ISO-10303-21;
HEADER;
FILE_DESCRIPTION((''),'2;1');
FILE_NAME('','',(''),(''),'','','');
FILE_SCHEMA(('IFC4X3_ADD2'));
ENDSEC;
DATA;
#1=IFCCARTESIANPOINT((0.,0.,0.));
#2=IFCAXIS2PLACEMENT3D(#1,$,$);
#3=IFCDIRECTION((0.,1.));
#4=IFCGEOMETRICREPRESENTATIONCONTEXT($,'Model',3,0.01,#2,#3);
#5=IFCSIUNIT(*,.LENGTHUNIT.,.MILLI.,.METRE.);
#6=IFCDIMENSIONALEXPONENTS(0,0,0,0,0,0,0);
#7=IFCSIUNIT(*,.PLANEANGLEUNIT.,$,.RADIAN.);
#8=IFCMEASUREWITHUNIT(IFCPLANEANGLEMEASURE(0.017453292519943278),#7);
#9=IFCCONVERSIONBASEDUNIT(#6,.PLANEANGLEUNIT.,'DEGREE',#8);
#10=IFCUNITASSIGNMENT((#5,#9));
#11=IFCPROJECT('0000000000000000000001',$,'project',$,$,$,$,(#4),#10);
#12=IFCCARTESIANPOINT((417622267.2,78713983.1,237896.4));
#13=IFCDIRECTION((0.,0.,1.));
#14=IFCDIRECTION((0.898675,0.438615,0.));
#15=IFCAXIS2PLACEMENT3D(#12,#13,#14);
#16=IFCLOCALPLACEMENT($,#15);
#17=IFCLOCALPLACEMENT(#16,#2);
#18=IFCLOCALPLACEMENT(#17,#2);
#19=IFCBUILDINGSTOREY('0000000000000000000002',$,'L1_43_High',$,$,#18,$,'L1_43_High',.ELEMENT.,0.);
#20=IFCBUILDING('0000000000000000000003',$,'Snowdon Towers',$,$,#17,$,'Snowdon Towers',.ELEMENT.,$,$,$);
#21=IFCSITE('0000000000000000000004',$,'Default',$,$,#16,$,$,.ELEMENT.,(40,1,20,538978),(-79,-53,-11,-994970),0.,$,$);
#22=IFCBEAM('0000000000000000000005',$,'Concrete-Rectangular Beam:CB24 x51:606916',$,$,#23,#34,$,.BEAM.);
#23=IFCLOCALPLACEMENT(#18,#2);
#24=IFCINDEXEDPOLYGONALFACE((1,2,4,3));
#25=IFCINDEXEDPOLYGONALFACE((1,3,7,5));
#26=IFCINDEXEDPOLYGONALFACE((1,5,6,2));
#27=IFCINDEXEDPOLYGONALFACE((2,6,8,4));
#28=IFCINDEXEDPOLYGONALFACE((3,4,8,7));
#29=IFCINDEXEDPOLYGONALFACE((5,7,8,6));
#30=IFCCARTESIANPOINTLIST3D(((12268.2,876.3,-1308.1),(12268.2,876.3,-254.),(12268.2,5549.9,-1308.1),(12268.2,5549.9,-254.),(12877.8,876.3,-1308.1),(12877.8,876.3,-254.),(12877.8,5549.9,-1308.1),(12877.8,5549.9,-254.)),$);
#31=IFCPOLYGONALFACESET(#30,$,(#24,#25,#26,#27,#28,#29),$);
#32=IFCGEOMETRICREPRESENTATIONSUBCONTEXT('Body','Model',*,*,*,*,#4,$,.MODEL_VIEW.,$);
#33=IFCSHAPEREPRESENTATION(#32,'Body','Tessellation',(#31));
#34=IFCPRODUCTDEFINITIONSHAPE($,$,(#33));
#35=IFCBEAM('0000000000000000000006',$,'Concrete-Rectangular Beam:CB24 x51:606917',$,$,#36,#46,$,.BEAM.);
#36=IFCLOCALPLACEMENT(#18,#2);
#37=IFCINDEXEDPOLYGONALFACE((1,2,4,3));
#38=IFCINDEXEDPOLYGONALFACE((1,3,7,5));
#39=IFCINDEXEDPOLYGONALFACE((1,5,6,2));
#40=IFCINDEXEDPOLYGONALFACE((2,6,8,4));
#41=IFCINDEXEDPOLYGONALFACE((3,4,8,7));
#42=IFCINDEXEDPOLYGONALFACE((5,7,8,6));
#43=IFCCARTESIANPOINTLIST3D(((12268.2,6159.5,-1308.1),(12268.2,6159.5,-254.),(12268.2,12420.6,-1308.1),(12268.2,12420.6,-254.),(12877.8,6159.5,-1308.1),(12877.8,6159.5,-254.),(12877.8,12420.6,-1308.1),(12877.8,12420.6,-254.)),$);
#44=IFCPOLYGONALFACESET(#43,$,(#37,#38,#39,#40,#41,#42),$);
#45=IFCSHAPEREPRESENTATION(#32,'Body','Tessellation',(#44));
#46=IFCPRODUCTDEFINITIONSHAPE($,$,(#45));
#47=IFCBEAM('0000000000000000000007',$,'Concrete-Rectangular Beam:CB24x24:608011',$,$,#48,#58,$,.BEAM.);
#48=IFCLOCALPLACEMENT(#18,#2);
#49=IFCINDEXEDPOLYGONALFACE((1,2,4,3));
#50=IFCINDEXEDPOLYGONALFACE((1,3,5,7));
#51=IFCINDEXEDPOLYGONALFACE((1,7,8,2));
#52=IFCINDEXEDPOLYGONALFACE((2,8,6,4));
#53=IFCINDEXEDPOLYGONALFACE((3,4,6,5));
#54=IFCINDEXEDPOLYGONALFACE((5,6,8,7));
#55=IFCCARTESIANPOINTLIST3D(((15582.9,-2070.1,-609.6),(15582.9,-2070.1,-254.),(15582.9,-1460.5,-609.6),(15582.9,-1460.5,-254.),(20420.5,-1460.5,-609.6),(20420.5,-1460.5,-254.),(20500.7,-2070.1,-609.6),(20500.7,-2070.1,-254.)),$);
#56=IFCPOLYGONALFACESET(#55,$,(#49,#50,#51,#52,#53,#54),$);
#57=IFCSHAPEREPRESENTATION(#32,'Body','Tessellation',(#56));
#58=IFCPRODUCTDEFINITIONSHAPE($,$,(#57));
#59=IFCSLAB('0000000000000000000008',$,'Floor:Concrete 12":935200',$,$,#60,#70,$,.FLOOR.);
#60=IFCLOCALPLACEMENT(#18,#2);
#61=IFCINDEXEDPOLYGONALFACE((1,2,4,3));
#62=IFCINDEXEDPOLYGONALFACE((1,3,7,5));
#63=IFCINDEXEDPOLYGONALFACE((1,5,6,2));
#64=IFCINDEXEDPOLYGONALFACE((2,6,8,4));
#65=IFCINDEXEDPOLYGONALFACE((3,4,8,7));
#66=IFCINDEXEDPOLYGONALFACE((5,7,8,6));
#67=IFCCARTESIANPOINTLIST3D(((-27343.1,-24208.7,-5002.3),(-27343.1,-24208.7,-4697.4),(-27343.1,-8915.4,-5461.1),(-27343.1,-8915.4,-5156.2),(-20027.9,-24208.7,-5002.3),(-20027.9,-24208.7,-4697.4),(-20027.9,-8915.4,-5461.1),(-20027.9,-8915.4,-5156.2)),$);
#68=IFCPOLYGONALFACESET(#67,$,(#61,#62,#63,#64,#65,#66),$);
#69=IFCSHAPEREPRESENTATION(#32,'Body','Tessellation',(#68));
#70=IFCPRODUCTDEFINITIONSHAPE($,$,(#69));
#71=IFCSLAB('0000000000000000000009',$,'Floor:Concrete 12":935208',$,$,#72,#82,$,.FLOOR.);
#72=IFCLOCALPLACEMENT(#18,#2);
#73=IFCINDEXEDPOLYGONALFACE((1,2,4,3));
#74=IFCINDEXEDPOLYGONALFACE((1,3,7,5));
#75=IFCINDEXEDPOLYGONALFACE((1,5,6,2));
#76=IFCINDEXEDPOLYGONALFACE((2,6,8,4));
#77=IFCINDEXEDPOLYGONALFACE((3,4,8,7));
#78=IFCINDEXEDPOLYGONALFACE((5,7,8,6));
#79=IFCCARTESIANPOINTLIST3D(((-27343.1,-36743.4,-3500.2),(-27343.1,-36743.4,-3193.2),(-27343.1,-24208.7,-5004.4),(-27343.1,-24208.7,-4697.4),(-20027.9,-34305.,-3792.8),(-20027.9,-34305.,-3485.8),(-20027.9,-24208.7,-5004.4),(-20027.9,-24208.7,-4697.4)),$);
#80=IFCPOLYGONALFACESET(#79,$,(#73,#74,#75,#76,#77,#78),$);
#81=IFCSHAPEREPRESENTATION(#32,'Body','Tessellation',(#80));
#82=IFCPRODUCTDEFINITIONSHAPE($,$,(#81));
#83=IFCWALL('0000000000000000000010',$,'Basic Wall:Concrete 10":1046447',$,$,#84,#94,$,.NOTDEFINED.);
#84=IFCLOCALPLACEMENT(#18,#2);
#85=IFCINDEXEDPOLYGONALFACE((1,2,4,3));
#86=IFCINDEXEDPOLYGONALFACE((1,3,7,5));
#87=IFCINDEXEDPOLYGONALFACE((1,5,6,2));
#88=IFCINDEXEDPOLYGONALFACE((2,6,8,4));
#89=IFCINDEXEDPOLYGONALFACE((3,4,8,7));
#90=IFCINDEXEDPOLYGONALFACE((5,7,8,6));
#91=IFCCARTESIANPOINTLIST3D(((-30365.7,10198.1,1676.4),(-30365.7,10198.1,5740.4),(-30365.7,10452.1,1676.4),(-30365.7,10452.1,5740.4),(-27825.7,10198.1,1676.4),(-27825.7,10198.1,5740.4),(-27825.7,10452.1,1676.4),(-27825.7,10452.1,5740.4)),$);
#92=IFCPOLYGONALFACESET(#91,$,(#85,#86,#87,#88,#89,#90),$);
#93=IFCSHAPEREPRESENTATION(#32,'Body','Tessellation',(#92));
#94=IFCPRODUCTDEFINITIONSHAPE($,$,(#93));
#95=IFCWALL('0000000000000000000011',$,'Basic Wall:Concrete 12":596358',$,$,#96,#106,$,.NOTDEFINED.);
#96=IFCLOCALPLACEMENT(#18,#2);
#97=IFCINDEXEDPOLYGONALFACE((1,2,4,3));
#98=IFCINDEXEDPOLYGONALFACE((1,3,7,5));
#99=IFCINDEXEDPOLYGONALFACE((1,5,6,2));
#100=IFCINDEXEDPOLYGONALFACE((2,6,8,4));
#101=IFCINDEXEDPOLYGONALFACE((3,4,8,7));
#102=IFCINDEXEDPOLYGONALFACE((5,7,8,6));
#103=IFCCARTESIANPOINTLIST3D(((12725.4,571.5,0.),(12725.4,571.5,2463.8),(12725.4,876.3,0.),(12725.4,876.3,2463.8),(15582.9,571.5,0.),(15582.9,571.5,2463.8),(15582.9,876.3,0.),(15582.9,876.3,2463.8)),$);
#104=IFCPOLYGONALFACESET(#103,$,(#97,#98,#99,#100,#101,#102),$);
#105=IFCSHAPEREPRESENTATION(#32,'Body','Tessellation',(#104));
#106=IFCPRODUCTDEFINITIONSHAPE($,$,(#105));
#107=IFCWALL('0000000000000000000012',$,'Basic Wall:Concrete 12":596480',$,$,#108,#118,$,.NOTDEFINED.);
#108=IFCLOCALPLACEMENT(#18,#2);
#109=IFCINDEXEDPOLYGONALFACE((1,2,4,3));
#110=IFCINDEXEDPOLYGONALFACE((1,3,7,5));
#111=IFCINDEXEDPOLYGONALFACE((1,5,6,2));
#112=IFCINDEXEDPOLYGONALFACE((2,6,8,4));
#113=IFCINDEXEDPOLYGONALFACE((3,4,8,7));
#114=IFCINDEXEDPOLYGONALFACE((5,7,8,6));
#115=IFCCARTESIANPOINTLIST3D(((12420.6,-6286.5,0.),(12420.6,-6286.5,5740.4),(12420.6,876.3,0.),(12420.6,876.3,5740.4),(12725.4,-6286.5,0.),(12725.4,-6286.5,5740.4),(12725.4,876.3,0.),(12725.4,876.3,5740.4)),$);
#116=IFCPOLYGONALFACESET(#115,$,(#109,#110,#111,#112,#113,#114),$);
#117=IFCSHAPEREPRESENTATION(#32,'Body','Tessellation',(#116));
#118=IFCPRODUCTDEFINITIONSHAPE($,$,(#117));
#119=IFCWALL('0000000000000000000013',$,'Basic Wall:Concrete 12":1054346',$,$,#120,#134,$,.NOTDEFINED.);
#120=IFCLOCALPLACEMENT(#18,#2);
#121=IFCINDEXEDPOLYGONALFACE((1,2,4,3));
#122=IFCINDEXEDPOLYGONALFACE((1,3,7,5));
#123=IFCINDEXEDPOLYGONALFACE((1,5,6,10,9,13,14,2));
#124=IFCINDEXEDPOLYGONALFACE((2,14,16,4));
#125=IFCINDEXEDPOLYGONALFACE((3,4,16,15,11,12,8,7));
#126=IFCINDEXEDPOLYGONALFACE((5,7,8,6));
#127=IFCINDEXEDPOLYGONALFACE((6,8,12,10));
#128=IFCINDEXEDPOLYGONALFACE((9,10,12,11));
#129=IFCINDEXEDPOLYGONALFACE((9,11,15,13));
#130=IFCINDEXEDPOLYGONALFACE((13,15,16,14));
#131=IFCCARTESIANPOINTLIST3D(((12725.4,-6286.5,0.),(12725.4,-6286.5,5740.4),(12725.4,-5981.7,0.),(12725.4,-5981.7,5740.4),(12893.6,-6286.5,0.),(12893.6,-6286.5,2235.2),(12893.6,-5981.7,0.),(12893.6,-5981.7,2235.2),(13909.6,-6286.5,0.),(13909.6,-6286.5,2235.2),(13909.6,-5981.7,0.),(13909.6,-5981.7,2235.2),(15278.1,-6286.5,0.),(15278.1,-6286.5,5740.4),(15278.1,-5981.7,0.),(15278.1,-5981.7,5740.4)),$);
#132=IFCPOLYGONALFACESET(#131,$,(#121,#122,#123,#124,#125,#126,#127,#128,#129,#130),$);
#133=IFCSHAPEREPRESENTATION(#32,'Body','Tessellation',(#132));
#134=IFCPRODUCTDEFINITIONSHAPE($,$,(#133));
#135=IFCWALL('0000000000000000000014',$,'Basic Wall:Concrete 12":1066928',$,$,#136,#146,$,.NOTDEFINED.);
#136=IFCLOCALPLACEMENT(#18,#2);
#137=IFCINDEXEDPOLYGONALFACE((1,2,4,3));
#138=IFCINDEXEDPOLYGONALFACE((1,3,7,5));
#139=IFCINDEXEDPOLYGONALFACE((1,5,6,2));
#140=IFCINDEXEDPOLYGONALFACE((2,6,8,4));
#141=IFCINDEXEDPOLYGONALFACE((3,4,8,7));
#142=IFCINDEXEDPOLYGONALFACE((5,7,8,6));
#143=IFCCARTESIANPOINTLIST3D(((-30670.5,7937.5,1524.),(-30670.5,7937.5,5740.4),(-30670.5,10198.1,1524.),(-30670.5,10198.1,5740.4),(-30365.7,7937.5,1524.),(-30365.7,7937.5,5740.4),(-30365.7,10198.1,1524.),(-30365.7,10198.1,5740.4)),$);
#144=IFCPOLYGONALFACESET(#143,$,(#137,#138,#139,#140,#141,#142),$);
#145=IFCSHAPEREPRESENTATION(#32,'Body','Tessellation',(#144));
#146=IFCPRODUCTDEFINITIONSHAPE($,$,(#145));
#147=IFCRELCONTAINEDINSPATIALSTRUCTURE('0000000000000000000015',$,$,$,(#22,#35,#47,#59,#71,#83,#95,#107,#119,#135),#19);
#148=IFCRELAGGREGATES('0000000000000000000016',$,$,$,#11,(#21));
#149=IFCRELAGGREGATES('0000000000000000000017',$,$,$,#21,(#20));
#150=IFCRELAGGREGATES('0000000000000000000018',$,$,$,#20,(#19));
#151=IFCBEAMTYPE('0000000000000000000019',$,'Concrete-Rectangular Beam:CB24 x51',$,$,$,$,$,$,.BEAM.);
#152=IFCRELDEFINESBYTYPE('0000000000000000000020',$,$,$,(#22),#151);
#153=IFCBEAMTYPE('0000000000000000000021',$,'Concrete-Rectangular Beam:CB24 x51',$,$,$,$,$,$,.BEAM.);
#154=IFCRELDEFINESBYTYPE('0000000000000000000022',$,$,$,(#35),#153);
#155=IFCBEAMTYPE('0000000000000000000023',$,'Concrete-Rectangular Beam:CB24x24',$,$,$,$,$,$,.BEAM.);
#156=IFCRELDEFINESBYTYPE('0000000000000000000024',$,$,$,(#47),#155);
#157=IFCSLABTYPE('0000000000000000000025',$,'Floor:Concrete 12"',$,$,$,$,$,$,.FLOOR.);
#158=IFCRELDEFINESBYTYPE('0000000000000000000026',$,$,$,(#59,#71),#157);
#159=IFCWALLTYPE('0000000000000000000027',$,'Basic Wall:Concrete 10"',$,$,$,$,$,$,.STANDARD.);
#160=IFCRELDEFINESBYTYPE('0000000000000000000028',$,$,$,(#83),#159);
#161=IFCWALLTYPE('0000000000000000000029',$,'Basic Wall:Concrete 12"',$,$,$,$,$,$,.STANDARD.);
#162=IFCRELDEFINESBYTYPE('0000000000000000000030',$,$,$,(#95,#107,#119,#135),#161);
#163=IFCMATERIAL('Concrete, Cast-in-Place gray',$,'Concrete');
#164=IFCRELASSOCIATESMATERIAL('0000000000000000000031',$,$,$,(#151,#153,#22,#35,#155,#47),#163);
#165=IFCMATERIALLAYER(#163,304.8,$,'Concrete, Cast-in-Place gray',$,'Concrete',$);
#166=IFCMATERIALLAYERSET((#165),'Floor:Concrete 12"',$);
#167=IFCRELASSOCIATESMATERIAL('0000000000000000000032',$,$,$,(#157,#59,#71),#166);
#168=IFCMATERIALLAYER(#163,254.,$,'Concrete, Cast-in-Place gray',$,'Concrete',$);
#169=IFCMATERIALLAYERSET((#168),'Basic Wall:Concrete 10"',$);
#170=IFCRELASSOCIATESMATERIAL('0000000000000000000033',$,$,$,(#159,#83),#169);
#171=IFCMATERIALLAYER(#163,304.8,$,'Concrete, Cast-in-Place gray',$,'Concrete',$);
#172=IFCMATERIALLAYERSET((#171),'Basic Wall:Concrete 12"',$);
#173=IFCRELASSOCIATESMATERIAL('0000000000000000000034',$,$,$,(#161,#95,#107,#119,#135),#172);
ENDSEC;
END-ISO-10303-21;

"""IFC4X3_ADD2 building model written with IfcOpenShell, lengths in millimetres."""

from ifc_helpers import new_model, entity, si_unit, converted_unit, direction, frame, frame_2d, origin, place, context, subcontext, project, spatial, polyline, rectangle, outline, extrude, clip, halfspace, source, transform, mapped, material, layer, layer_set, layer_usage, material_profile, profile_set, profile_usage, type_object, type_shapes, element, save


model = new_model("IFC4X3_ADD2")

# Units and contexts
model_context = context("Model", 3, precision=0.01, world=origin(), true_north=direction((0.0, 1.0)))
body_context = subcontext(model_context, "Body", "Model", "MODEL_VIEW")
ifc_project = project(units=[si_unit("LENGTHUNIT", "METRE", prefix="MILLI"), converted_unit("PLANEANGLEUNIT", "DEGREE", entity("IfcPlaneAngleMeasure", 0.017453292519943278), si_unit("PLANEANGLEUNIT", "RADIAN"), dimensions=[0, 0, 0, 0, 0, 0, 0])], contexts=[model_context])

# Site, building, storey
site_placement = place(None, frame((417622267.2, 78713983.1, 237896.4), z_axis=(0.0, 0.0, 1.0), x_axis=(0.898675, 0.438615, 0.0)))
site = spatial("IfcSite", under=ifc_project, at=site_placement, Name="Default", CompositionType="ELEMENT", RefLatitude=(40, 1, 20, 538978), RefLongitude=(-79, -53, -11, -994970), RefElevation=0.0)
building_placement = place(site_placement, origin())
building = spatial("IfcBuilding", under=site, at=building_placement, Name="Snowdon Towers", LongName="Snowdon Towers", CompositionType="ELEMENT")
storey_placement = place(building_placement, origin())
storey = spatial("IfcBuildingStorey", under=building, at=storey_placement, Name="L1_43_High", LongName="L1_43_High", CompositionType="ELEMENT", Elevation=0.0)

# Beams
ifc_material_1 = material(Name="Concrete, Cast-in-Place gray", Category="Concrete")
ifc_material_profile_1 = material_profile(ifc_material_1, rectangle(XDim=355.6, YDim=609.6, at=frame_2d((0.0, 0.0), x_axis=(1.0, 0.0))), Name="CB24x24")
ifc_profile_set_1 = profile_set([ifc_material_profile_1], Name="CB24x24")
ifc_profile_usage_1 = profile_usage(ifc_profile_set_1, cardinal=8)
ifc_material_profile_2 = material_profile(ifc_material_1, rectangle(XDim=1054.1, YDim=609.6, at=frame_2d((0.0, 0.0), x_axis=(0.0, 1.0))), Name="CB24 x51")
ifc_profile_set_2 = profile_set([ifc_material_profile_2], Name="CB24 x51")
ifc_profile_usage_2 = profile_usage(ifc_profile_set_2, cardinal=8)
beam_type_1 = type_object("IfcBeamType", Name="Concrete-Rectangular Beam:CB24 x51", PredefinedType="BEAM", material=ifc_profile_set_2)
shared_shape_1 = source(origin(), body_context, "Body", "SweptSolid", [
    extrude(rectangle(XDim=1054.1, YDim=609.6, at=frame_2d((0.0, 0.0), x_axis=(0.0, 1.0))), frame((12573.0, 876.3, -781.0), z_axis=(0.0, 1.0, 0.0), x_axis=(-1.0, 0.0, 0.0)), (0.0, 0.0, 1.0), 4673.6),
])
type_shapes(beam_type_1, [shared_shape_1])
beam_1_placement = place(storey_placement, origin())
element("IfcBeam", 1, at=beam_1_placement, inside=storey, type_object=beam_type_1, material=ifc_profile_usage_2, Name="Concrete-Rectangular Beam:CB24 x51:606916", PredefinedType="BEAM", context=body_context, shape_type="MappedRepresentation", body=[
    mapped(shared_shape_1, transform((0.0, 0.0, 0.0), scale=1.0)),
])
beam_type_2 = type_object("IfcBeamType", Name="Concrete-Rectangular Beam:CB24 x51", PredefinedType="BEAM", material=ifc_profile_set_2)
shared_shape_2 = source(origin(), body_context, "Body", "SweptSolid", [
    extrude(rectangle(XDim=1054.1, YDim=609.6, at=frame_2d((0.0, 0.0), x_axis=(0.0, 1.0))), frame((12573.0, 6159.5, -781.0), z_axis=(0.0, 1.0, 0.0), x_axis=(-1.0, 0.0, 0.0)), (0.0, 0.0, 1.0), 6261.1),
])
type_shapes(beam_type_2, [shared_shape_2])
beam_2_placement = place(storey_placement, origin())
element("IfcBeam", 2, at=beam_2_placement, inside=storey, type_object=beam_type_2, material=ifc_profile_usage_2, Name="Concrete-Rectangular Beam:CB24 x51:606917", PredefinedType="BEAM", context=body_context, shape_type="MappedRepresentation", body=[
    mapped(shared_shape_2, transform((0.0, 0.0, 0.0), scale=1.0)),
])
beam_type_3 = type_object("IfcBeamType", Name="Concrete-Rectangular Beam:CB24x24", PredefinedType="BEAM", material=ifc_profile_set_1)
shared_shape_3 = source(origin(), body_context, "Body", "Clipping", [
    clip(extrude(rectangle(XDim=355.6, YDim=609.6, at=frame_2d((0.0, 0.0), x_axis=(1.0, 0.0))), frame((15582.9, -1765.3, -431.8), z_axis=(1.0, 0.0, 0.0), x_axis=(0.0, 0.0, -1.0)), (0.0, 0.0, 1.0), 4917.8), halfspace(frame((18529.5, 12902.8, -5334.0), z_axis=(0.991445, 0.130526, 0.0), x_axis=(0.130526, -0.991445, 0.0)), False)),
])
type_shapes(beam_type_3, [shared_shape_3])
beam_3_placement = place(storey_placement, origin())
element("IfcBeam", 3, at=beam_3_placement, inside=storey, type_object=beam_type_3, material=ifc_profile_usage_1, Name="Concrete-Rectangular Beam:CB24x24:608011", PredefinedType="BEAM", context=body_context, shape_type="MappedRepresentation", body=[
    mapped(shared_shape_3, transform((0.0, 0.0, 0.0), scale=1.0)),
])

# Slabs
ifc_layer_1 = layer(ifc_material_1, 304.8, Name="Concrete, Cast-in-Place gray", Category="Concrete")
ifc_layer_set_1 = layer_set([ifc_layer_1], Name="Floor:Concrete 12\"")
ifc_layer_usage_1 = layer_usage(ifc_layer_set_1, "AXIS3", "POSITIVE", 0.0)
slab_type_1 = type_object("IfcSlabType", Name="Floor:Concrete 12\"", PredefinedType="FLOOR", material=ifc_layer_set_1)
slab_1_placement = place(storey_placement, origin())
element("IfcSlab", 4, at=slab_1_placement, inside=storey, type_object=slab_type_1, material=ifc_layer_usage_1, Name="Floor:Concrete 12\":935200", PredefinedType="FLOOR", context=body_context, shape_type="Clipping", body=[
    clip(clip(extrude(rectangle(XDim=15300.2, YDim=7315.2, at=frame_2d((0.0, 0.0), x_axis=(1.0, 0.0))), frame((-23685.5, -16562.1, -4926.8), z_axis=(0.0, -0.029987, -0.99955), x_axis=(0.0, 0.99955, -0.029987)), (0.029987, 0.0, 0.99955), 305.1), halfspace(frame((-23685.5, -8915.4, -5461.1), z_axis=(0.0, -0.029987, -0.99955), x_axis=(0.0, -0.99955, 0.029987)), False)), halfspace(frame((-23685.5, -8915.4, -5156.2), z_axis=(0.0, 0.029987, 0.99955), x_axis=(0.0, 0.99955, -0.029987)), False)),
])
ifc_layer_usage_2 = layer_usage(ifc_layer_set_1, "AXIS3", "POSITIVE", 0.0)
slab_2_placement = place(storey_placement, origin())
element("IfcSlab", 5, at=slab_2_placement, inside=storey, type_object=slab_type_1, material=ifc_layer_usage_2, Name="Floor:Concrete 12\":935208", PredefinedType="FLOOR", context=body_context, shape_type="Clipping", body=[
    clip(clip(extrude(outline(polyline([(-6926.3, -3657.6), (5698.3, -3657.6), (5698.3, 3657.6), (-4470.4, 3657.6), (-6926.3, -3657.6)])), frame((-23685.5, -29866.5, -4018.5), z_axis=(0.0, -0.119145, -0.992877), x_axis=(0.0, 0.992877, -0.119145)), (0.119145, 0.0, 0.992877), 309.2), halfspace(frame((-23685.5, -24208.7, -5004.4), z_axis=(0.0, -0.119145, -0.992877), x_axis=(0.0, -0.992877, 0.119145)), False)), halfspace(frame((-23685.5, -24208.7, -4697.4), z_axis=(0.0, 0.119145, 0.992877), x_axis=(0.0, 0.992877, -0.119145)), False)),
])

# Walls
ifc_layer_2 = layer(ifc_material_1, 254.0, Name="Concrete, Cast-in-Place gray", Category="Concrete")
ifc_layer_set_2 = layer_set([ifc_layer_2], Name="Basic Wall:Concrete 10\"")
wall_type_1 = type_object("IfcWallType", Name="Basic Wall:Concrete 10\"", PredefinedType="STANDARD", material=ifc_layer_set_2)
wall_1_placement = place(storey_placement, frame((-30365.7, 10325.1, 1676.4)))
element("IfcWall", 6, at=wall_1_placement, inside=storey, type_object=wall_type_1, material=ifc_layer_set_2, Name="Basic Wall:Concrete 10\":1046447", PredefinedType="NOTDEFINED", context=body_context, shape_type="SweptSolid", body=[
    extrude(rectangle(XDim=2540.0, YDim=254.0, at=frame_2d((1270.0, 0.0), x_axis=(-1.0, 0.0))), origin(), (0.0, 0.0, 1.0), 4064.0),
])
ifc_layer_3 = layer(ifc_material_1, 304.8, Name="Concrete, Cast-in-Place gray", Category="Concrete")
ifc_layer_set_3 = layer_set([ifc_layer_3], Name="Basic Wall:Concrete 12\"")
wall_type_2 = type_object("IfcWallType", Name="Basic Wall:Concrete 12\"", PredefinedType="STANDARD", material=ifc_layer_set_3)
wall_2_placement = place(storey_placement, frame((15582.9, 723.9, 0.0), z_axis=(0.0, 0.0, 1.0), x_axis=(-1.0, 0.0, 0.0)))
element("IfcWall", 7, at=wall_2_placement, inside=storey, type_object=wall_type_2, material=ifc_layer_set_3, Name="Basic Wall:Concrete 12\":596358", PredefinedType="NOTDEFINED", context=body_context, shape_type="SweptSolid", body=[
    extrude(rectangle(XDim=2857.5, YDim=304.8, at=frame_2d((1428.8, 0.0), x_axis=(-1.0, 0.0))), origin(), (0.0, 0.0, 1.0), 2463.8),
])
wall_3_placement = place(storey_placement, frame((12573.0, 876.3, 0.0), z_axis=(0.0, 0.0, 1.0), x_axis=(0.0, -1.0, 0.0)))
element("IfcWall", 8, at=wall_3_placement, inside=storey, type_object=wall_type_2, material=ifc_layer_set_3, Name="Basic Wall:Concrete 12\":596480", PredefinedType="NOTDEFINED", context=body_context, shape_type="SweptSolid", body=[
    extrude(rectangle(XDim=7162.8, YDim=304.8, at=frame_2d((3581.4, 0.0), x_axis=(-1.0, 0.0))), origin(), (0.0, 0.0, 1.0), 5740.4),
])

# Wall, opening
wall_4_placement = place(storey_placement, frame((15278.1, -6134.1, 0.0), z_axis=(0.0, 0.0, 1.0), x_axis=(-1.0, 0.0, 0.0)))
wall_4 = element("IfcWall", 9, at=wall_4_placement, inside=storey, type_object=wall_type_2, material=ifc_layer_set_3, Name="Basic Wall:Concrete 12\":1054346", PredefinedType="NOTDEFINED", context=body_context, shape_type="SweptSolid", body=[
    extrude(rectangle(XDim=2552.7, YDim=304.8, at=frame_2d((1276.3, 0.0), x_axis=(-1.0, 0.0))), origin(), (0.0, 0.0, 1.0), 5740.4),
])
opening_placement = place(wall_4_placement, origin())
element("IfcOpeningElement", 10, at=opening_placement, cuts=wall_4, PredefinedType="OPENING", context=body_context, shape_type="SweptSolid", body=[
    extrude(rectangle(XDim=2235.2, YDim=1016.0, at=frame_2d((0.0, 0.0), x_axis=(0.0, 1.0))), frame((1876.5, 152.4, 1117.6), z_axis=(0.0, -1.0, 0.0), x_axis=(1.0, 0.0, 0.0)), (0.0, 0.0, 1.0), 304.8),
])

# Wall
wall_5_placement = place(storey_placement, frame((-30518.1, 7937.5, 1524.0), z_axis=(0.0, 0.0, 1.0), x_axis=(0.0, 1.0, 0.0)))
element("IfcWall", 11, at=wall_5_placement, inside=storey, type_object=wall_type_2, material=ifc_layer_set_3, Name="Basic Wall:Concrete 12\":1066928", PredefinedType="NOTDEFINED", context=body_context, shape_type="SweptSolid", body=[
    extrude(rectangle(XDim=2260.6, YDim=304.8, at=frame_2d((1130.3, 0.0), x_axis=(-1.0, 0.0))), origin(), (0.0, 0.0, 1.0), 4216.4),
])

save(model, "model.ifc")
